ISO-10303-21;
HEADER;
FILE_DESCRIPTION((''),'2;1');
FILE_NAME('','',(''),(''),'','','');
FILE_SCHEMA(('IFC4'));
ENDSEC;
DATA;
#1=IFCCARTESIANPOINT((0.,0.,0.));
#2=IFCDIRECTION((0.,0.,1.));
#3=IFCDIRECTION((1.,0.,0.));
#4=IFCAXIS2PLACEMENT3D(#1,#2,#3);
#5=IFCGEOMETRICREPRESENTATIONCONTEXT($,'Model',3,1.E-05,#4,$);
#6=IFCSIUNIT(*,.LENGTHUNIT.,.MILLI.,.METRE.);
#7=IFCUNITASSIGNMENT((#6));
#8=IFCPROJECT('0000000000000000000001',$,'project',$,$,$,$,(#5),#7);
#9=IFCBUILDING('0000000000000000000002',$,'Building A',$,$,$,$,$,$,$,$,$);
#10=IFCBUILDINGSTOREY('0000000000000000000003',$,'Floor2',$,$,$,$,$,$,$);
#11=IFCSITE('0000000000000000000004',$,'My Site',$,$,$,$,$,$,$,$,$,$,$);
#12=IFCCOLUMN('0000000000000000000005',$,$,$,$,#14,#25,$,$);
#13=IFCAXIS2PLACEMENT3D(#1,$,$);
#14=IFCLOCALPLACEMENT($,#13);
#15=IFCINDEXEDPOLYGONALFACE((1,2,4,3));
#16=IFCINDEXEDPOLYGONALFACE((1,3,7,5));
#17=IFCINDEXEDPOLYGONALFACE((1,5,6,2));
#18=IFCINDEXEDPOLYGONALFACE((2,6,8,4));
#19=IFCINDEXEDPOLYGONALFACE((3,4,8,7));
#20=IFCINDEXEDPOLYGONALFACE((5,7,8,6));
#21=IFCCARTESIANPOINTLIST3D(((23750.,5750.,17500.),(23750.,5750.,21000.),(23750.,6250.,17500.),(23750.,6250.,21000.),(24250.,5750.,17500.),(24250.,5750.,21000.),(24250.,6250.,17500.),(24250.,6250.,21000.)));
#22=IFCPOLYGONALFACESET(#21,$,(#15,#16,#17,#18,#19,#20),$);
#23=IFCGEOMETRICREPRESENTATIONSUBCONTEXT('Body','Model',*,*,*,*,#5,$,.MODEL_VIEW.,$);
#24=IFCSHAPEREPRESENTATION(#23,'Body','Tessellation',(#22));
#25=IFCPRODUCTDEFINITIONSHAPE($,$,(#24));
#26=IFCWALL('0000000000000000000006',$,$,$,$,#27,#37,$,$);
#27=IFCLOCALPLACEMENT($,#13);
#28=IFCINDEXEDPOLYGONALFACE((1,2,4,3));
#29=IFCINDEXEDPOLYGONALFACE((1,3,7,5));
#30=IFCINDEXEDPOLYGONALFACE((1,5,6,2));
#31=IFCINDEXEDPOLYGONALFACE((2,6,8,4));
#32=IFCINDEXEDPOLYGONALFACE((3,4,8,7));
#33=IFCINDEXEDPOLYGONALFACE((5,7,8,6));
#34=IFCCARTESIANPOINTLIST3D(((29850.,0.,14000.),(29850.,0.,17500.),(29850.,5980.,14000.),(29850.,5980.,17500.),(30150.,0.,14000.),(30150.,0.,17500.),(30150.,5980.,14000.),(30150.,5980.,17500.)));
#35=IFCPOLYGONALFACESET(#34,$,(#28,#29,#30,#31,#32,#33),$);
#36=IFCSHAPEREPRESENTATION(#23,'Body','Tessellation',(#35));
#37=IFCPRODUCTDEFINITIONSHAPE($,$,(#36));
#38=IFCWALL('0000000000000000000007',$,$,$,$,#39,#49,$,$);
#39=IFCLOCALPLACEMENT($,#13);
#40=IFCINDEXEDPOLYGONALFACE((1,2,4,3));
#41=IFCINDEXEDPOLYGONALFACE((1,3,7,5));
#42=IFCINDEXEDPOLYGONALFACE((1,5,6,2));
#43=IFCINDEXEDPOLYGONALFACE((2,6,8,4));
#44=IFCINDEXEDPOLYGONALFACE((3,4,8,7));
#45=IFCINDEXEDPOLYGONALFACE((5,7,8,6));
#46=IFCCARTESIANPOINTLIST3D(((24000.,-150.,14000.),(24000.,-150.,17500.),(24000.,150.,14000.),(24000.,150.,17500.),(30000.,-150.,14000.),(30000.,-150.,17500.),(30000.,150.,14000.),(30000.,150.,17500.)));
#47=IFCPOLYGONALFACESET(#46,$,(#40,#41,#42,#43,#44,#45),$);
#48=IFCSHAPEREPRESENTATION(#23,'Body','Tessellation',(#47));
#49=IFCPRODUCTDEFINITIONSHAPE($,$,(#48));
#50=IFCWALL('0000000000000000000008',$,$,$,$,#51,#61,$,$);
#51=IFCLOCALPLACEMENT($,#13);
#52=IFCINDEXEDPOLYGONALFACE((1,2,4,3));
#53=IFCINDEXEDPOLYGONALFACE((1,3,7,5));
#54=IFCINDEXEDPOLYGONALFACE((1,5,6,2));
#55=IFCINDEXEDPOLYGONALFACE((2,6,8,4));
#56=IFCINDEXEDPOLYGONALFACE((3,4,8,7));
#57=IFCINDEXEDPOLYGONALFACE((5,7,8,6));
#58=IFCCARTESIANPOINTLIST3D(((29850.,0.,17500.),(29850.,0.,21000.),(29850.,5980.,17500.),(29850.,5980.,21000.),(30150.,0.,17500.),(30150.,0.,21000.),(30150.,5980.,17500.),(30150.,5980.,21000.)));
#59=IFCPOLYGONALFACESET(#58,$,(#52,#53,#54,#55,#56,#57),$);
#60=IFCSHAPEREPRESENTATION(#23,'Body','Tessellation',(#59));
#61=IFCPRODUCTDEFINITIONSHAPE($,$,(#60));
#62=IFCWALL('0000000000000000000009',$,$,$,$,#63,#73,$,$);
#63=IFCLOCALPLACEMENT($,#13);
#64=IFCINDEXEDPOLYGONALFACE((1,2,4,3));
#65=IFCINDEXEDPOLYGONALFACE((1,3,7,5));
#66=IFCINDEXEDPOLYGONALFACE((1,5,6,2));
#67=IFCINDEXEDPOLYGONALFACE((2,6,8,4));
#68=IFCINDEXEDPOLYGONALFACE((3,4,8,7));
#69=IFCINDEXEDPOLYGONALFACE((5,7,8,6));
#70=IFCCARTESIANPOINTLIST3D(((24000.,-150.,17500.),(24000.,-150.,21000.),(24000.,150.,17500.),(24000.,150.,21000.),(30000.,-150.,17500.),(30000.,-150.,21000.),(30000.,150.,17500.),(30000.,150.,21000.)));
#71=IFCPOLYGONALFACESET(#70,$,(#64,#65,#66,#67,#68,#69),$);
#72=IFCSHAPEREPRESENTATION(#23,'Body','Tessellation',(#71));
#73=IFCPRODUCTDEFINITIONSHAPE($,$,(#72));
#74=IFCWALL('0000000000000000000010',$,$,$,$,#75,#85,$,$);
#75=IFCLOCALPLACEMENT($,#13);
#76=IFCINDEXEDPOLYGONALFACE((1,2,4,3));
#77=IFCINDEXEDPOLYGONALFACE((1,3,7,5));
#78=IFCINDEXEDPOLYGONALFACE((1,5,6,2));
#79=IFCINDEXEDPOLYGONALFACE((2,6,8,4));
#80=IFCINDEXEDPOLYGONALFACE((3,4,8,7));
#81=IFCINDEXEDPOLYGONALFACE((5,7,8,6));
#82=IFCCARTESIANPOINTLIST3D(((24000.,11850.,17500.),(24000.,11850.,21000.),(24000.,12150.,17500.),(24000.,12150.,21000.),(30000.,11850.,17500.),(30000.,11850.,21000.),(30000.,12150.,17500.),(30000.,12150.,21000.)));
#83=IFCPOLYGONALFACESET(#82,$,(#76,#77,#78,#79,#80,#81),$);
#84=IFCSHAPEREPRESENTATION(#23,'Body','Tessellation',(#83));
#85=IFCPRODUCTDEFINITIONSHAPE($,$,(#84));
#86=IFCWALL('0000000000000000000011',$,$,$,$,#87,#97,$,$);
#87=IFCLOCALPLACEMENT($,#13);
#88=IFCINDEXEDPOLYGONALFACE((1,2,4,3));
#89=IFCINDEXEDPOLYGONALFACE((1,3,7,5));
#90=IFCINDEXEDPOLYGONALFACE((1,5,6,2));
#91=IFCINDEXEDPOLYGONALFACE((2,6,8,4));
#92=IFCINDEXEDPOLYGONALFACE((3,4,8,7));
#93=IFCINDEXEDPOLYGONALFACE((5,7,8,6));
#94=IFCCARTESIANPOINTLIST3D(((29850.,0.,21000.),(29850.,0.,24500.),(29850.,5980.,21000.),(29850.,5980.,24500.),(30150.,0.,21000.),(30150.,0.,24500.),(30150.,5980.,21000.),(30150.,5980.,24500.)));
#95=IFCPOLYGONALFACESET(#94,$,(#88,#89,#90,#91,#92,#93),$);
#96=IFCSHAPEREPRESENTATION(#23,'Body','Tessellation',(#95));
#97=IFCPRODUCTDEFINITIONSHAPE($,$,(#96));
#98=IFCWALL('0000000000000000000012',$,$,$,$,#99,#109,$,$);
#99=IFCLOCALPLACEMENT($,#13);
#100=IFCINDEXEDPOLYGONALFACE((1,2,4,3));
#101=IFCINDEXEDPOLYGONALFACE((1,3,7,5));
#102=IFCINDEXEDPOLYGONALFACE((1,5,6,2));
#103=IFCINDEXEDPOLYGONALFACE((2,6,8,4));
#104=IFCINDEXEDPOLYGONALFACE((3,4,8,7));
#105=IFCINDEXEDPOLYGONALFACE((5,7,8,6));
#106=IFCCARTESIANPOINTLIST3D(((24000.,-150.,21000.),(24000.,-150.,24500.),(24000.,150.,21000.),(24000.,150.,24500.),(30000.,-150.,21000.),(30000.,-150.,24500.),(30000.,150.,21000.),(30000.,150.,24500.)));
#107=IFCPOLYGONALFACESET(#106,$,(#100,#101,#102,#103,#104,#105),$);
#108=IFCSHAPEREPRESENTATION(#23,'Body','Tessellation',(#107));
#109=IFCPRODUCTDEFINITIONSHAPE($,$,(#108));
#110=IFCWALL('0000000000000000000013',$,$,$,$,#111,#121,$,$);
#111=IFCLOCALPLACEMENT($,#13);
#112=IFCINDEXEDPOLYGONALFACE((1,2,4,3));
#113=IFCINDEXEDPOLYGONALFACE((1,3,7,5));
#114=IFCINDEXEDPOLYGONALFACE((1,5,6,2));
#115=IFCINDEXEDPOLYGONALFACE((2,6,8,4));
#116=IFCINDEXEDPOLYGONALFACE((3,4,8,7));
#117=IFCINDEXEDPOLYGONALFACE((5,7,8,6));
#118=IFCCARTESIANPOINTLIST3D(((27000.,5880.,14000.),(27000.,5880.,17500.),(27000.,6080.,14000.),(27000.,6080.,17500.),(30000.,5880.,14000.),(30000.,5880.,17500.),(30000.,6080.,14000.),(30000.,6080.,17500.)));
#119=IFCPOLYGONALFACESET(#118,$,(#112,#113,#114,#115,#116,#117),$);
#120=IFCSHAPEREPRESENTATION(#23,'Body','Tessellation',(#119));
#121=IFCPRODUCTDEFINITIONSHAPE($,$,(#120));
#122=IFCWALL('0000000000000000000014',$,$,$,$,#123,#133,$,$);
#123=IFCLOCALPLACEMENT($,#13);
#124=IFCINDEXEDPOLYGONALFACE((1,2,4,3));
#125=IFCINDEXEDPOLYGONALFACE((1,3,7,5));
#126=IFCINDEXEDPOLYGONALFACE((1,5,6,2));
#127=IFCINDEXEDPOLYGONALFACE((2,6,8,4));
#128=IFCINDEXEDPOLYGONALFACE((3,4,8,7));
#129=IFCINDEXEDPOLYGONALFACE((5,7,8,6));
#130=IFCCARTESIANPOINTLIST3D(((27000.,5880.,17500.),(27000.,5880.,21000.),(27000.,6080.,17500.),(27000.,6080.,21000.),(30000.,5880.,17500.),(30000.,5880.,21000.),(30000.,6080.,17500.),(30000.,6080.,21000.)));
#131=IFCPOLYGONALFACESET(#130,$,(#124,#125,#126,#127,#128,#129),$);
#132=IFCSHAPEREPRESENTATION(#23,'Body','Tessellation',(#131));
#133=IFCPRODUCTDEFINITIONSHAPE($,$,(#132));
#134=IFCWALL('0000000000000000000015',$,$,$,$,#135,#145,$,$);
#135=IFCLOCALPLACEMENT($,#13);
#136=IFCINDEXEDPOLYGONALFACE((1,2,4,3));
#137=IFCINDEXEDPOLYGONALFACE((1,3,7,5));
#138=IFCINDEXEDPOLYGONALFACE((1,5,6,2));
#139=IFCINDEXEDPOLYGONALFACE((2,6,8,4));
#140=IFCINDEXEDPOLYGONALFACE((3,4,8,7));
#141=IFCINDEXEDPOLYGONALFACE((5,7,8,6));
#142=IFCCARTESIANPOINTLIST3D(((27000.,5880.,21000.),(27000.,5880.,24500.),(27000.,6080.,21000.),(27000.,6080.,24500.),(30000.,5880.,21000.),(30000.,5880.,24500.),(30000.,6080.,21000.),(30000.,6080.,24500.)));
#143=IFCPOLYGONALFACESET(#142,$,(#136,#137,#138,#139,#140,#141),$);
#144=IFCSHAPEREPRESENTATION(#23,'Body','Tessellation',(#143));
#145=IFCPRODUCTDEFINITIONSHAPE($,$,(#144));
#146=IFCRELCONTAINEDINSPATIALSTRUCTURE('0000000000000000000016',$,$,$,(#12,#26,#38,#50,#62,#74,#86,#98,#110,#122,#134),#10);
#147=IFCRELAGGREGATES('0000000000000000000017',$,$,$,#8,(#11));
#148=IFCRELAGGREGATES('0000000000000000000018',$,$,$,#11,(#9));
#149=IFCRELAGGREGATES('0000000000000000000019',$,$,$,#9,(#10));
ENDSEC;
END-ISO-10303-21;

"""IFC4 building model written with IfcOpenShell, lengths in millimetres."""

from ifc_helpers import new_model, si_unit, frame, origin_with_axes, place, context, subcontext, project, spatial, line, indexed_curve, outline, extrude, element, save


model = new_model("IFC4")

# Units and contexts
model_context = context("Model", 3, precision=1e-05, world=origin_with_axes())
body_context = subcontext(model_context, "Body", "Model", "MODEL_VIEW")
ifc_project = project(units=[si_unit("LENGTHUNIT", "METRE", prefix="MILLI")], contexts=[model_context])

# Site, building, storey
site = spatial("IfcSite", under=ifc_project, Name="My Site")
building = spatial("IfcBuilding", under=site, Name="Building A")
storey = spatial("IfcBuildingStorey", under=building, Name="Floor2")

# Column
column_placement = place(None, frame((24000.0, 6000.0, 17500.0), z_axis=(0.0, 0.0, 1.0), x_axis=(1.0, 0.0, 0.0)))
element("IfcColumn", 1, at=column_placement, inside=storey, context=body_context, shape_type="SweptSolid", body=[
    extrude(outline(indexed_curve([(-250.0, -250.0), (250.0, -250.0), (250.0, 250.0), (-250.0, 250.0)], segments=[line(1, 2, 3, 4, 1)])), origin_with_axes(), (0.0, 0.0, 1.0), 3500.0),
])

# Walls
wall_1_placement = place(None, frame((29850.0, 5980.0, 14000.0), z_axis=(0.0, 0.0, 1.0), x_axis=(0.0, -1.0, 0.0)))
element("IfcWall", 2, at=wall_1_placement, inside=storey, context=body_context, shape_type="SweptSolid", body=[
    extrude(outline(indexed_curve([(0.0, 0.0), (0.0, 300.0), (5980.0, 300.0), (5980.0, 0.0), (0.0, 0.0)], self_intersect=False)), origin_with_axes(), (0.0, 0.0, 1.0), 3500.0),
])
wall_2_placement = place(None, frame((30000.0, 150.0, 14000.0), z_axis=(0.0, 0.0, 1.0), x_axis=(-1.0, 0.0, 0.0)))
element("IfcWall", 3, at=wall_2_placement, inside=storey, context=body_context, shape_type="SweptSolid", body=[
    extrude(outline(indexed_curve([(0.0, 0.0), (0.0, 300.0), (6000.0, 300.0), (6000.0, 0.0), (0.0, 0.0)], self_intersect=False)), origin_with_axes(), (0.0, 0.0, 1.0), 3500.0),
])
wall_3_placement = place(None, frame((29850.0, 5980.0, 17500.0), z_axis=(0.0, 0.0, 1.0), x_axis=(0.0, -1.0, 0.0)))
element("IfcWall", 4, at=wall_3_placement, inside=storey, context=body_context, shape_type="SweptSolid", body=[
    extrude(outline(indexed_curve([(0.0, 0.0), (0.0, 300.0), (5980.0, 300.0), (5980.0, 0.0), (0.0, 0.0)], self_intersect=False)), origin_with_axes(), (0.0, 0.0, 1.0), 3500.0),
])
for number, where, z_axis, x_axis in (
    (5, (30000.0, 150.0, 17500.0), (0.0, 0.0, 1.0), (-1.0, 0.0, 0.0)),
    (6, (24000.0, 11850.0, 17500.0), (0.0, 0.0, 1.0), (1.0, 0.0, 0.0)),
):
    element("IfcWall", number, at=place(None, frame(where, z_axis=z_axis, x_axis=x_axis)), inside=storey, context=body_context, shape_type="SweptSolid", body=[
        extrude(outline(indexed_curve([(0.0, 0.0), (0.0, 300.0), (6000.0, 300.0), (6000.0, 0.0), (0.0, 0.0)], self_intersect=False)), origin_with_axes(), (0.0, 0.0, 1.0), 3500.0),
    ])
wall_4_placement = place(None, frame((29850.0, 5980.0, 21000.0), z_axis=(0.0, 0.0, 1.0), x_axis=(0.0, -1.0, 0.0)))
element("IfcWall", 7, at=wall_4_placement, inside=storey, context=body_context, shape_type="SweptSolid", body=[
    extrude(outline(indexed_curve([(0.0, 0.0), (0.0, 300.0), (5980.0, 300.0), (5980.0, 0.0), (0.0, 0.0)], self_intersect=False)), origin_with_axes(), (0.0, 0.0, 1.0), 3500.0),
])
wall_5_placement = place(None, frame((30000.0, 150.0, 21000.0), z_axis=(0.0, 0.0, 1.0), x_axis=(-1.0, 0.0, 0.0)))
element("IfcWall", 8, at=wall_5_placement, inside=storey, context=body_context, shape_type="SweptSolid", body=[
    extrude(outline(indexed_curve([(0.0, 0.0), (0.0, 300.0), (6000.0, 300.0), (6000.0, 0.0), (0.0, 0.0)], self_intersect=False)), origin_with_axes(), (0.0, 0.0, 1.0), 3500.0),
])
for number, where, z_axis, x_axis in (
    (9, (27000.0, 5880.0, 14000.0), (0.0, 0.0, 1.0), (1.0, 0.0, 0.0)),
    (10, (27000.0, 5880.0, 17500.0), (0.0, 0.0, 1.0), (1.0, 0.0, 0.0)),
    (11, (27000.0, 5880.0, 21000.0), (0.0, 0.0, 1.0), (1.0, 0.0, 0.0)),
):
    element("IfcWall", number, at=place(None, frame(where, z_axis=z_axis, x_axis=x_axis)), inside=storey, context=body_context, shape_type="SweptSolid", body=[
        extrude(outline(indexed_curve([(0.0, 0.0), (0.0, 200.0), (3000.0, 200.0), (3000.0, 0.0), (0.0, 0.0)], self_intersect=False)), origin_with_axes(), (0.0, 0.0, 1.0), 3500.0),
    ])

save(model, "model.ifc")
